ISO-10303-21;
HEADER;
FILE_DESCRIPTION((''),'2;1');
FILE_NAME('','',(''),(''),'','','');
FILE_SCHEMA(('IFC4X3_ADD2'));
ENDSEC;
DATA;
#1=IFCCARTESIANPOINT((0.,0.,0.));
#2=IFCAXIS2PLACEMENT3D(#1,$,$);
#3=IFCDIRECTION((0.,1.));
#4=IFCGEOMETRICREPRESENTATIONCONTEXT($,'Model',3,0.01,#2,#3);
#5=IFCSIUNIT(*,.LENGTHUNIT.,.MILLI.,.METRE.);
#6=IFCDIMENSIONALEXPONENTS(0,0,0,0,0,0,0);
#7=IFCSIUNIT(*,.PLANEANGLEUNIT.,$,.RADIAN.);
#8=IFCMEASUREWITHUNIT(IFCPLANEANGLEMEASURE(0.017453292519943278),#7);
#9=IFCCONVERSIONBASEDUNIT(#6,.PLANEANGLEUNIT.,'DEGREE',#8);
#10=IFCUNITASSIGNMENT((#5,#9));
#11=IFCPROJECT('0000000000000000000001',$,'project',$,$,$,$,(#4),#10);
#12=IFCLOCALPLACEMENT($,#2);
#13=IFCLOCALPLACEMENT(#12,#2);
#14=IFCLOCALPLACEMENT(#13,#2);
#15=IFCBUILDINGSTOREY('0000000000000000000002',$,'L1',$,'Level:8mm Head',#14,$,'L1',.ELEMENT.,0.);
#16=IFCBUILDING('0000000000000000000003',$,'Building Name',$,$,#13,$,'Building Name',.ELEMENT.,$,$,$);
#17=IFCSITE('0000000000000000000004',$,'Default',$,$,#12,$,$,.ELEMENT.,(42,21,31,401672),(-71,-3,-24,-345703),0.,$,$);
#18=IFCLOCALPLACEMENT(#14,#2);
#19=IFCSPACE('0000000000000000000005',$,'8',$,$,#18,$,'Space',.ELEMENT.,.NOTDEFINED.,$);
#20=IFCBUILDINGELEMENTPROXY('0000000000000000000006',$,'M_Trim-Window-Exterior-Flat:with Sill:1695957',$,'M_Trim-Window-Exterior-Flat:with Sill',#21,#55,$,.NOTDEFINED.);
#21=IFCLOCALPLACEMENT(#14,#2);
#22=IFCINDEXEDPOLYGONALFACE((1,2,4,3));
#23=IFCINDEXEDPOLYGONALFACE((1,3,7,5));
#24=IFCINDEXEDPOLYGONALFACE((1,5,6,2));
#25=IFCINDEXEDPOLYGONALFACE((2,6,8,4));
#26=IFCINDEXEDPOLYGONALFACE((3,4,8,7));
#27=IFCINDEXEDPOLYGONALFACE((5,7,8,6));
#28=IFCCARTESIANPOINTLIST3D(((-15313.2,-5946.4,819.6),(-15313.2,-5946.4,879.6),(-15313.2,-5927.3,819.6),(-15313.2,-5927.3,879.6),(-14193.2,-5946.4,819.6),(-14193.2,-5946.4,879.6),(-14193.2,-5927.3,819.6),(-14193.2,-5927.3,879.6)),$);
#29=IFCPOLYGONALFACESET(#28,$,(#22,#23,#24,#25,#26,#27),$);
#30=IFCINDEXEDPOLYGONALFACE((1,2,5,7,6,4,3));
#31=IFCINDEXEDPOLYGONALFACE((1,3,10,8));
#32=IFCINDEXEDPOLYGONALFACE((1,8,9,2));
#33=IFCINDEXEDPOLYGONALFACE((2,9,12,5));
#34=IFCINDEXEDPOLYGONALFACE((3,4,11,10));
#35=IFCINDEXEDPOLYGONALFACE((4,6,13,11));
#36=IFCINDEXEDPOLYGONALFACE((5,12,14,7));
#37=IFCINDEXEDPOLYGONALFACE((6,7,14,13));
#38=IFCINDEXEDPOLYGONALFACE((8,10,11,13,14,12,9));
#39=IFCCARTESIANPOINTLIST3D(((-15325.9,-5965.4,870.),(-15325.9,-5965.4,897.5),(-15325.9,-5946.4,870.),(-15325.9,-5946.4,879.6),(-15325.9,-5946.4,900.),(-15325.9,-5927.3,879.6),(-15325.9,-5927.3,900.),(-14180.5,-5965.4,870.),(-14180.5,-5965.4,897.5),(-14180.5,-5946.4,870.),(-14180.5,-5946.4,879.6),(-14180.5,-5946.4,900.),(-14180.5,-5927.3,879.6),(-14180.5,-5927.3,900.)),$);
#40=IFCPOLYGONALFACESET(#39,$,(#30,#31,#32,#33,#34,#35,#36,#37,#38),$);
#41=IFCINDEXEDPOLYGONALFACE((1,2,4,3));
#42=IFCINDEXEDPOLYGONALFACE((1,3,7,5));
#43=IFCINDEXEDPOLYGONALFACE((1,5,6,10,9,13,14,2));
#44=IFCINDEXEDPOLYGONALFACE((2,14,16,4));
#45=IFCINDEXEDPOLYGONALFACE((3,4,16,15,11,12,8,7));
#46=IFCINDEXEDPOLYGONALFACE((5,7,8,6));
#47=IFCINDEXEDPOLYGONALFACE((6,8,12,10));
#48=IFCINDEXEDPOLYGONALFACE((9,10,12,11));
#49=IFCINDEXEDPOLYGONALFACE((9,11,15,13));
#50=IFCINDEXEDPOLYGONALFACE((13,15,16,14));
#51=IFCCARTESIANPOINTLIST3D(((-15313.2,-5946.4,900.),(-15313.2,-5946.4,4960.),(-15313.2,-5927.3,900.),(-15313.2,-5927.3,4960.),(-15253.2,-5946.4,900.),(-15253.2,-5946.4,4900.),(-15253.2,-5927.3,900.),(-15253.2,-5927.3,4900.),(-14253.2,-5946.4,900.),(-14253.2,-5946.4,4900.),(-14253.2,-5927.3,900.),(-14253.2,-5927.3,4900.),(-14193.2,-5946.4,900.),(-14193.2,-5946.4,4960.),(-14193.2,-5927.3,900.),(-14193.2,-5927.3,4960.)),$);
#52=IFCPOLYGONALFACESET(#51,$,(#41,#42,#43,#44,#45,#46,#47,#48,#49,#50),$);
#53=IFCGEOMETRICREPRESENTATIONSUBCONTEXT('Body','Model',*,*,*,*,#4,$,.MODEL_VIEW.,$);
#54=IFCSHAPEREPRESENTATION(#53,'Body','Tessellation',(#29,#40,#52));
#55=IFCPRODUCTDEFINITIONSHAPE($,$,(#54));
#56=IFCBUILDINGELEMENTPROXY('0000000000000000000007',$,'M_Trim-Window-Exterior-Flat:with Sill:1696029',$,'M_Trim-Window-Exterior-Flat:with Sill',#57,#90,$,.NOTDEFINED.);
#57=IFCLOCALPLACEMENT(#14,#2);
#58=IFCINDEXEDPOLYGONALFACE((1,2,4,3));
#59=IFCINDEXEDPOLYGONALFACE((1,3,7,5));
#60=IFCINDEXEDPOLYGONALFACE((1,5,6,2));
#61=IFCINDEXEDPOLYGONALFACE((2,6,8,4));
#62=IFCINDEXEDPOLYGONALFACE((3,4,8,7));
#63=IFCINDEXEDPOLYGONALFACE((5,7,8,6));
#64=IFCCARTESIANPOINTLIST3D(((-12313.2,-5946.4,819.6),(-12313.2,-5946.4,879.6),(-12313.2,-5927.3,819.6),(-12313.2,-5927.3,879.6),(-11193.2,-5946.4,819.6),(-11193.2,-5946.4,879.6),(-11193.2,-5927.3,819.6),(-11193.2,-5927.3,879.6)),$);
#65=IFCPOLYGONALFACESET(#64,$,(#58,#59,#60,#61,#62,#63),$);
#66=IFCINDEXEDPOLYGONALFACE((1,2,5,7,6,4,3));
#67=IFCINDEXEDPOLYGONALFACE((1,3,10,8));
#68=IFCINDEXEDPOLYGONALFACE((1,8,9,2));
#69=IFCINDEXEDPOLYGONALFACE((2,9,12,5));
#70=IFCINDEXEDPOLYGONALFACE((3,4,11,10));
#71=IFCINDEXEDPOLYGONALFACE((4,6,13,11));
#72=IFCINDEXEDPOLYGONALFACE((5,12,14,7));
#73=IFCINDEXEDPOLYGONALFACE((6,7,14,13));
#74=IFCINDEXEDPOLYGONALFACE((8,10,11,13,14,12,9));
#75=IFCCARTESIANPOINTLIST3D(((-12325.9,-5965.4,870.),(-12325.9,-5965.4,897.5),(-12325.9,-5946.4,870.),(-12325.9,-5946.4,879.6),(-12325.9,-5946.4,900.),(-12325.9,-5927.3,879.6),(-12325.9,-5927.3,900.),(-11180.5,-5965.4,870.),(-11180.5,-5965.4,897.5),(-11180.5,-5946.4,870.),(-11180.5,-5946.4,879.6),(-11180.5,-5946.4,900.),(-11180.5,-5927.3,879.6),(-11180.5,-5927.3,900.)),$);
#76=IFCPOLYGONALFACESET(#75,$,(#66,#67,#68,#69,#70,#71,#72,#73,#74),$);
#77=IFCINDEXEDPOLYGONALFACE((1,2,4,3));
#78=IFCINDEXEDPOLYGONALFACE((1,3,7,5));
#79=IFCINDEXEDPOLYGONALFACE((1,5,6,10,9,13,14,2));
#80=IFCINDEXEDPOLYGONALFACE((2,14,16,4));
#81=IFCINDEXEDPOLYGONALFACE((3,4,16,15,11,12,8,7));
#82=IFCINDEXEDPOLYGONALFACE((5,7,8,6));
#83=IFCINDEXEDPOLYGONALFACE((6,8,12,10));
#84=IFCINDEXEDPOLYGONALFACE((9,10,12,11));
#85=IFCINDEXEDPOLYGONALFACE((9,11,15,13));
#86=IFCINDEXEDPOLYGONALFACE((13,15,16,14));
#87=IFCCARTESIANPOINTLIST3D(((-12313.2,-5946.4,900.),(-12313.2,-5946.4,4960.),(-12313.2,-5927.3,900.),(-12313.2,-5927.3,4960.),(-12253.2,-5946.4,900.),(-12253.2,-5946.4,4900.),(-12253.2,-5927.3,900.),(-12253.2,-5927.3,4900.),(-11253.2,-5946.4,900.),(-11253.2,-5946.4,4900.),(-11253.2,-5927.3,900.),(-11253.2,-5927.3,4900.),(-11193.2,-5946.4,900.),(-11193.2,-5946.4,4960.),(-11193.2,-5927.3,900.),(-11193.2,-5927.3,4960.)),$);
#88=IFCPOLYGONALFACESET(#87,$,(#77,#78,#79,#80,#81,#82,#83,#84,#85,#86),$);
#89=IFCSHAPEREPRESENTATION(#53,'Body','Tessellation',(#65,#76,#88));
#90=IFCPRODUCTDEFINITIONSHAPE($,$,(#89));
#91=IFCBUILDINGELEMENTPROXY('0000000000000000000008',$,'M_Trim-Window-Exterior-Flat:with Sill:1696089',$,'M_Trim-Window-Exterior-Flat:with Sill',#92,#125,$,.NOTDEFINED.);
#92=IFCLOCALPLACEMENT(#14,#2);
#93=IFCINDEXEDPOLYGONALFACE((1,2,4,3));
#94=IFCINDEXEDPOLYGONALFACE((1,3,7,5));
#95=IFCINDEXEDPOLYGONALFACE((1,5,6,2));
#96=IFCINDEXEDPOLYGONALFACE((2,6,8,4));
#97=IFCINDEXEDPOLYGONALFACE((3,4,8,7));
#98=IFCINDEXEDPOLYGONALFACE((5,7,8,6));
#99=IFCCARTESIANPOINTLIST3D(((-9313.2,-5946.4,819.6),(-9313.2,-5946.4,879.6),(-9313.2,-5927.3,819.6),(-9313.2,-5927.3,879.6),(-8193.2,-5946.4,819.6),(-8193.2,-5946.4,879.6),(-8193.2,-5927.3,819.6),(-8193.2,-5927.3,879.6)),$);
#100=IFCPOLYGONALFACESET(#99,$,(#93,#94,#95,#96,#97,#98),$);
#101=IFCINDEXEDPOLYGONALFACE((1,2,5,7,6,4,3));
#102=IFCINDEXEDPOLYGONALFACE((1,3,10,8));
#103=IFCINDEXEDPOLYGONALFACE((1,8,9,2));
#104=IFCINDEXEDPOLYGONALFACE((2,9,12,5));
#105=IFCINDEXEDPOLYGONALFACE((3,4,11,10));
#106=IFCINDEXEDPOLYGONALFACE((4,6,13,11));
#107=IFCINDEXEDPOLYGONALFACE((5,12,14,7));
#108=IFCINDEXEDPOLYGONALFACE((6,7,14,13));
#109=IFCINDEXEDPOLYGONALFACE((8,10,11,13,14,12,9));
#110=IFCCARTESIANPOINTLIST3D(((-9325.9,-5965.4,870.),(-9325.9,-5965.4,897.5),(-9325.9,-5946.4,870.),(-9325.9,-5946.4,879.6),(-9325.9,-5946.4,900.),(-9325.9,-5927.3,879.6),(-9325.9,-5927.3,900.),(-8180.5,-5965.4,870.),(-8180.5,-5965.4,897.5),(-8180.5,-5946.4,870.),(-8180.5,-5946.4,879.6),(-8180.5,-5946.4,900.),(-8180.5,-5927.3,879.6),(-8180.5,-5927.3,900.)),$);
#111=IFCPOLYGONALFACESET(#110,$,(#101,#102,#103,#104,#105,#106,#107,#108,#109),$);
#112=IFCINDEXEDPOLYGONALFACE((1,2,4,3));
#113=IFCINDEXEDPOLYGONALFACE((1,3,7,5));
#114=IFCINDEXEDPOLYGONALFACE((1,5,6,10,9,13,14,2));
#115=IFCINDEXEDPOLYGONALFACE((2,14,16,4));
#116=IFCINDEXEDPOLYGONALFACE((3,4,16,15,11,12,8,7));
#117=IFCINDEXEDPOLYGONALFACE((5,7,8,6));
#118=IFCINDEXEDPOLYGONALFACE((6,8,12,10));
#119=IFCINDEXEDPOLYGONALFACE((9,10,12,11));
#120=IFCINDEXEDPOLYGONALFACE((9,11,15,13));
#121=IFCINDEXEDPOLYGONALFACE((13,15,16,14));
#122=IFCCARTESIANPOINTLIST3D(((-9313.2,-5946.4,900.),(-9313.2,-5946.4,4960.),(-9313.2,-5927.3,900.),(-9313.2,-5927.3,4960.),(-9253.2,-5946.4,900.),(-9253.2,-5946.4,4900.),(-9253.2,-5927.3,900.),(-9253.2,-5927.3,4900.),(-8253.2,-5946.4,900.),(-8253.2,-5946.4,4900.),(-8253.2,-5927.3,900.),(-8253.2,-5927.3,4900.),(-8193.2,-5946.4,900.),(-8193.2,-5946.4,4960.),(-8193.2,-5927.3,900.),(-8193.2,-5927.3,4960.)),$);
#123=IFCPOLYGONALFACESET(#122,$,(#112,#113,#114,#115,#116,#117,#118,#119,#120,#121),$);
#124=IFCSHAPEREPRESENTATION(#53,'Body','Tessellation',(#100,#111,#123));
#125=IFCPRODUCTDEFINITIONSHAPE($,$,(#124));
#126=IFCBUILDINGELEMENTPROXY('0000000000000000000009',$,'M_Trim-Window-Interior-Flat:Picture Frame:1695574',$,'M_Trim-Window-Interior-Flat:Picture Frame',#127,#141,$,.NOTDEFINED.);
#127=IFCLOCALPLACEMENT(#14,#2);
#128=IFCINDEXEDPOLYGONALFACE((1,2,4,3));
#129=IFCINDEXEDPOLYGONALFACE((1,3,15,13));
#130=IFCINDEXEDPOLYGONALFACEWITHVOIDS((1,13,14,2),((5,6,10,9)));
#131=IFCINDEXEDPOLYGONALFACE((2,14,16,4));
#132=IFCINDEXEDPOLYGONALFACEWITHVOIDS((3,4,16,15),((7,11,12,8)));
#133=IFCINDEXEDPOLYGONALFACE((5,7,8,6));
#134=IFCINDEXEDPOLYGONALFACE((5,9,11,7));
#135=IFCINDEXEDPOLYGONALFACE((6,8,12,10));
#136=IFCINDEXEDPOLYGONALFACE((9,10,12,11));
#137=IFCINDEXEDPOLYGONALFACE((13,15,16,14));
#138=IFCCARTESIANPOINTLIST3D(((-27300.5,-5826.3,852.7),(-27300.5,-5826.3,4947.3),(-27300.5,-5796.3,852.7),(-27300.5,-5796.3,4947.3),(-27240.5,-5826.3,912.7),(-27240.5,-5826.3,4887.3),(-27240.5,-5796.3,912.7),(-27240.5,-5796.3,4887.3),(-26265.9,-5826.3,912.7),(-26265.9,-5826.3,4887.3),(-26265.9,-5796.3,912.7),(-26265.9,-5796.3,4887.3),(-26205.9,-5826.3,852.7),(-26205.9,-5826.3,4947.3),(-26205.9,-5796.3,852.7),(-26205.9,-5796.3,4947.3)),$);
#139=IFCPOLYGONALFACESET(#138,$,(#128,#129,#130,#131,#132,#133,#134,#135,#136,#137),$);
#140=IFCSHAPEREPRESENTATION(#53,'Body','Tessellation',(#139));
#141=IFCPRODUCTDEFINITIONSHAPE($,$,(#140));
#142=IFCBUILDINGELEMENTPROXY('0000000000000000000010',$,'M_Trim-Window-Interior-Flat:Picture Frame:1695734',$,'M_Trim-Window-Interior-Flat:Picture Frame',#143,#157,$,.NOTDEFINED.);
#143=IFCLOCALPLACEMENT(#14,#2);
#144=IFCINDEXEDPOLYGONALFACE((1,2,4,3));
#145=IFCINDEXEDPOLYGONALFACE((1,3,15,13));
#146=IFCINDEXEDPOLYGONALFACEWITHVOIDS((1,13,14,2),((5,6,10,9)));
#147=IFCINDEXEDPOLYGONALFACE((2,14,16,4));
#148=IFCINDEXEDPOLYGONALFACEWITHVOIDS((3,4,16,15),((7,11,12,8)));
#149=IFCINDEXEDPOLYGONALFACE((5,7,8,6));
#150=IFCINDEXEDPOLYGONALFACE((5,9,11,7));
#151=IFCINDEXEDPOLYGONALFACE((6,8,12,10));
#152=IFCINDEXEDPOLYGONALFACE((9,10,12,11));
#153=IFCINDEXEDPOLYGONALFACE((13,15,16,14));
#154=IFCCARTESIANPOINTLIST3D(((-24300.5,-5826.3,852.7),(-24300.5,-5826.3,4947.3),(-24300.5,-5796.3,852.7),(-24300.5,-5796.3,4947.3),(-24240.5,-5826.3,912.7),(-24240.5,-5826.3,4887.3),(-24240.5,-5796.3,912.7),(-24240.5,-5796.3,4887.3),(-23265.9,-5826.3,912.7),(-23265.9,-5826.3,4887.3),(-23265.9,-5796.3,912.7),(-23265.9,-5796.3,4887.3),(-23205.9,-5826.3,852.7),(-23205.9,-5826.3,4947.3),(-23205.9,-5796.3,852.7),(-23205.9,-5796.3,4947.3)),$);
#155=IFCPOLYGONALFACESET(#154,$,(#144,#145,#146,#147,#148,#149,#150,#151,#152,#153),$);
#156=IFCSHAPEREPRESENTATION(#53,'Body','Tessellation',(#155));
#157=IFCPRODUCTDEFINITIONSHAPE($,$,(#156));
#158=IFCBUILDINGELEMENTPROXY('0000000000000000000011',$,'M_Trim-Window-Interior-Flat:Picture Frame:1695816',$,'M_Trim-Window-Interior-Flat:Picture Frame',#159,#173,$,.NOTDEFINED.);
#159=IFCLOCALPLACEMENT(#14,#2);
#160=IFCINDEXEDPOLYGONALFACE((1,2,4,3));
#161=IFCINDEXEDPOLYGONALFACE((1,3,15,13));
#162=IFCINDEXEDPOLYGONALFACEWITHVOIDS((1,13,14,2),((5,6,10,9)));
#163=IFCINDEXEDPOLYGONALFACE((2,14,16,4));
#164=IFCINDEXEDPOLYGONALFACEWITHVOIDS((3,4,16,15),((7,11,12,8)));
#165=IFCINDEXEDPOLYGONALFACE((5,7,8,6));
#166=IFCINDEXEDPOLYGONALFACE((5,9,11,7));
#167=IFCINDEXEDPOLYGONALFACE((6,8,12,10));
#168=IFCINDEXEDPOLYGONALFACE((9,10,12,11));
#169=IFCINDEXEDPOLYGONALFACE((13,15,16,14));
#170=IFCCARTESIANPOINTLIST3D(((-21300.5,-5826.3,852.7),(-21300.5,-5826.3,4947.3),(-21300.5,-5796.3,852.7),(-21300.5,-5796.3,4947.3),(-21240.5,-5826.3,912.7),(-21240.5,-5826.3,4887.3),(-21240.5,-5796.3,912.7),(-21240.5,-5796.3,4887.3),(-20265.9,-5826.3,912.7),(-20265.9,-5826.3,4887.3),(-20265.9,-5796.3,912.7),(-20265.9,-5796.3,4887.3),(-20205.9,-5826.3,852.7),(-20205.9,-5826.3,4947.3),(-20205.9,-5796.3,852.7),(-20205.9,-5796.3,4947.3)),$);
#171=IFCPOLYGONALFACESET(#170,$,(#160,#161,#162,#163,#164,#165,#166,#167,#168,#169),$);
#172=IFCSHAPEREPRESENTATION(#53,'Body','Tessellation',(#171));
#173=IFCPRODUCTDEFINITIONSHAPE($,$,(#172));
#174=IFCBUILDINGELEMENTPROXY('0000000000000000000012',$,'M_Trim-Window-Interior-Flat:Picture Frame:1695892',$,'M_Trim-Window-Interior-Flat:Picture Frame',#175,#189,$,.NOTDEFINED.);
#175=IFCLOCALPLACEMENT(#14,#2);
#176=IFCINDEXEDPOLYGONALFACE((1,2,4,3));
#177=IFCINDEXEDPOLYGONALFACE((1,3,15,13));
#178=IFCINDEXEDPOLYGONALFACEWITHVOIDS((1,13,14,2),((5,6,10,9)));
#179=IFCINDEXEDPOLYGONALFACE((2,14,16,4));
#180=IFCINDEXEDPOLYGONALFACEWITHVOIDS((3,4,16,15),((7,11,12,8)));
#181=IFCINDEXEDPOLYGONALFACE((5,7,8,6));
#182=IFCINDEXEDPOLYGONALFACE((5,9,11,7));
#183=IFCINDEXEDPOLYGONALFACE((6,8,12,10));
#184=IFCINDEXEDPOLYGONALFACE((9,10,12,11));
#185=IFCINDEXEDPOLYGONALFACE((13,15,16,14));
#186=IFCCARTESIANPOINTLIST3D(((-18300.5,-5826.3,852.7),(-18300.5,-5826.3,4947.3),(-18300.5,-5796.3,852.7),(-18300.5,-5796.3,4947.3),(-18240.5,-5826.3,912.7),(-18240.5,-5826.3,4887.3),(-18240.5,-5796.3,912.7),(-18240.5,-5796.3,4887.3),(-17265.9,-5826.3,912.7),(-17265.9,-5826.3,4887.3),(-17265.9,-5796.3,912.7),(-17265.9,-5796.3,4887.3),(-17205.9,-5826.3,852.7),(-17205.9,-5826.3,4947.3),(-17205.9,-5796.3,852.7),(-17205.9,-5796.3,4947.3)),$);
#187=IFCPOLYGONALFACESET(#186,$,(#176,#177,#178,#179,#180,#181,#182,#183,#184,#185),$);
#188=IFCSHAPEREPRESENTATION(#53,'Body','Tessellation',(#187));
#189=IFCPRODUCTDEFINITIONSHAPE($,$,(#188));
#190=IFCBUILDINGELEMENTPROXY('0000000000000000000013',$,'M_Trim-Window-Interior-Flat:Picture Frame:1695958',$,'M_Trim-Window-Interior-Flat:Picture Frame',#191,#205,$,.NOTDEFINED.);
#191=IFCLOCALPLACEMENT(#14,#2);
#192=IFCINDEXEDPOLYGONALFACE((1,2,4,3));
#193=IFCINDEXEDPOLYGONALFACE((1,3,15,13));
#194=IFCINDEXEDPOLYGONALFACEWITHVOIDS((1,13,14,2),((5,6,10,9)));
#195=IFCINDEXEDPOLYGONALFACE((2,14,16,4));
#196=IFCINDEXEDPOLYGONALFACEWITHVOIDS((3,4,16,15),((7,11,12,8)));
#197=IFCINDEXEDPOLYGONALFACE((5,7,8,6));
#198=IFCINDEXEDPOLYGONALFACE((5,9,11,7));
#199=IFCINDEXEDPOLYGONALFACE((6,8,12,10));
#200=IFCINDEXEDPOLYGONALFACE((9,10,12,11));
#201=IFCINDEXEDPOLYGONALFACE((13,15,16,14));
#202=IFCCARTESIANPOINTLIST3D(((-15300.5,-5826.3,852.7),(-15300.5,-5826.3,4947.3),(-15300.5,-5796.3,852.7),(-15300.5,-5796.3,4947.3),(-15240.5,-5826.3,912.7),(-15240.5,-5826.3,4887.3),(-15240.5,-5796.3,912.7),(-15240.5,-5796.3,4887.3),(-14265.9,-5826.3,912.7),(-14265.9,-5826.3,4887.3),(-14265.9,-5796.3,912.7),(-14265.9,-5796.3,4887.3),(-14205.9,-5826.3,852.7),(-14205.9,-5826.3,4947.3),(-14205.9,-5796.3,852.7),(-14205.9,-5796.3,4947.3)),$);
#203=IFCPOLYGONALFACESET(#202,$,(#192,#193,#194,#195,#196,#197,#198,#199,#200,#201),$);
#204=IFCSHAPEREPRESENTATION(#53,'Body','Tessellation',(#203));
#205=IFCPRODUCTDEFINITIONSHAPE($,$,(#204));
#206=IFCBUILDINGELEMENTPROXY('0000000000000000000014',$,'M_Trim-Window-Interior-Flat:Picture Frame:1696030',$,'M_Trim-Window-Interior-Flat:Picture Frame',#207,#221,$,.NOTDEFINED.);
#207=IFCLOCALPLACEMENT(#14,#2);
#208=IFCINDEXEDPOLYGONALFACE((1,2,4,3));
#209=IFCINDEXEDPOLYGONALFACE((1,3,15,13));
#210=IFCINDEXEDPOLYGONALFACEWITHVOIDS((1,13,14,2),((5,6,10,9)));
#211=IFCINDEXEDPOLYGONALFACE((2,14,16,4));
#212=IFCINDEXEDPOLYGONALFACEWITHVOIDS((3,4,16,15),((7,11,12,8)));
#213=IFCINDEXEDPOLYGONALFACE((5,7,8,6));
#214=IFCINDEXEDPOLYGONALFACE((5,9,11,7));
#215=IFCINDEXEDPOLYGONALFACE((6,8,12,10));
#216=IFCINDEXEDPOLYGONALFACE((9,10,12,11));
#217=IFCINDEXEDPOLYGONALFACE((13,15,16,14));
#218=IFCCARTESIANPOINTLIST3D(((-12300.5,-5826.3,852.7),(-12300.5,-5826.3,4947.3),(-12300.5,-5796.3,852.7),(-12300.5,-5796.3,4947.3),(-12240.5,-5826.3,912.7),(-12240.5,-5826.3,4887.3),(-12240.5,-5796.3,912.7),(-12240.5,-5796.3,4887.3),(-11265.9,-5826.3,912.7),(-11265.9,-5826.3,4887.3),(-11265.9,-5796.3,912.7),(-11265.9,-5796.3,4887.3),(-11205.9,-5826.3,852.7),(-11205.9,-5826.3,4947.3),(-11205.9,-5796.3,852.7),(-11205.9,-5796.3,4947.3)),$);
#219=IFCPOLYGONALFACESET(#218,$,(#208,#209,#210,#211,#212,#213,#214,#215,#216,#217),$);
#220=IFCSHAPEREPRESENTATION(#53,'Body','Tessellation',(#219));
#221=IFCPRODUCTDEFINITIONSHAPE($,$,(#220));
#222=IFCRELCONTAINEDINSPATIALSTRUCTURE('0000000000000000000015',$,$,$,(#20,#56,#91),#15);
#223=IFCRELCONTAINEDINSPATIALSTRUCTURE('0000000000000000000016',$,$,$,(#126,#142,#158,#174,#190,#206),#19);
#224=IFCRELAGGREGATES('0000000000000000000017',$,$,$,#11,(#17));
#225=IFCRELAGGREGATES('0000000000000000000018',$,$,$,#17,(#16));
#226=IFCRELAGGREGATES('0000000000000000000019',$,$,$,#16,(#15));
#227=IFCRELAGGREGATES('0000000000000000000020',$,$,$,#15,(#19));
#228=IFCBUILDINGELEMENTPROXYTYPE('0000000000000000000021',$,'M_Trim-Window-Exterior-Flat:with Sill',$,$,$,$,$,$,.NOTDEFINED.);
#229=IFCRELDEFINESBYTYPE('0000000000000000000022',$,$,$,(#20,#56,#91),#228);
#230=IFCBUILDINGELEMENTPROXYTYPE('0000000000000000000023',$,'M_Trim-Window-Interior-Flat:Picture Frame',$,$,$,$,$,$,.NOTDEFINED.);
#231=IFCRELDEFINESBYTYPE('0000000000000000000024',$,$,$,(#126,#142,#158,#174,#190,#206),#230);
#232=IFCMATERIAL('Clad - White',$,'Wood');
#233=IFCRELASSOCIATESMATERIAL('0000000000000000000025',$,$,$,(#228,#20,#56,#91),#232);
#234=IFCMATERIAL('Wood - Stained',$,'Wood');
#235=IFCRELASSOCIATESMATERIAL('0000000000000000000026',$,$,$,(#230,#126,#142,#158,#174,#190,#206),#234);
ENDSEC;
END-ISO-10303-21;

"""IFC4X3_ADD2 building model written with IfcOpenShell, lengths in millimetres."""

from ifc_helpers import new_model, entity, si_unit, converted_unit, direction, frame, frame_2d, origin, place, context, subcontext, project, spatial, polyline, rectangle, outline, extrude, source, transform, mapped, material, type_object, type_shapes, element, save


model = new_model("IFC4X3_ADD2")

# Units and contexts
model_context = context("Model", 3, precision=0.01, world=origin(), true_north=direction((0.0, 1.0)))
body_context = subcontext(model_context, "Body", "Model", "MODEL_VIEW")
ifc_project = project(units=[si_unit("LENGTHUNIT", "METRE", prefix="MILLI"), converted_unit("PLANEANGLEUNIT", "DEGREE", entity("IfcPlaneAngleMeasure", 0.017453292519943278), si_unit("PLANEANGLEUNIT", "RADIAN"), dimensions=[0, 0, 0, 0, 0, 0, 0])], contexts=[model_context])

# Site, building, storey
site_placement = place(None, origin())
site = spatial("IfcSite", under=ifc_project, at=site_placement, Name="Default", CompositionType="ELEMENT", RefLatitude=(42, 21, 31, 401672), RefLongitude=(-71, -3, -24, -345703), RefElevation=0.0)
building_placement = place(site_placement, origin())
building = spatial("IfcBuilding", under=site, at=building_placement, Name="Building Name", LongName="Building Name", CompositionType="ELEMENT")
storey_placement = place(building_placement, origin())
storey = spatial("IfcBuildingStorey", under=building, at=storey_placement, Name="L1", ObjectType="Level:8mm Head", LongName="L1", CompositionType="ELEMENT", Elevation=0.0)

# Building element proxies
ifc_material_1 = material(Name="Clad - White", Category="Wood")
ifc_material_2 = material(Name="Wood - Stained", Category="Wood")
building_element_proxy_type_1 = type_object("IfcBuildingElementProxyType", Name="M_Trim-Window-Exterior-Flat:with Sill", PredefinedType="NOTDEFINED", material=ifc_material_1)
shared_shape_1 = source(origin(), body_context, "Body", "SweptSolid", [
    extrude(rectangle(XDim=1120.0, YDim=60.0, at=frame_2d((0.0, 0.0), x_axis=(1.0, 0.0))), frame((0.0, -4050.4, 0.0), z_axis=(0.0, 0.0, 1.0), x_axis=(-1.0, 0.0, 0.0)), (0.0, 0.0, 1.0), 19.0),
    extrude(outline(polyline([(-19.0, -15.2), (0.0, -15.2), (0.0, -5.7), (19.0, -5.7), (19.0, 14.8), (0.0, 14.8), (-19.0, 12.3), (-19.0, -15.2)])), frame((-572.7, -4014.8, 19.0), z_axis=(1.0, 0.0, 0.0), x_axis=(0.0, 0.0, -1.0)), (0.0, 0.0, 1.0), 1145.4),
    extrude(outline(polyline([(-2045.0, -560.0), (2015.0, -560.0), (2015.0, -500.0), (-1985.0, -500.0), (-1985.0, 500.0), (2015.0, 500.0), (2015.0, 560.0), (-2045.0, 560.0), (-2045.0, -560.0)])), frame((0.0, -1985.0, 0.0), z_axis=(0.0, 0.0, 1.0), x_axis=(0.0, -1.0, 0.0)), (0.0, 0.0, 1.0), 19.0),
])
type_shapes(building_element_proxy_type_1, [shared_shape_1])
for number, where, z_axis, x_axis, name in (
    (1, (-14753.2, -5927.3, 4900.0), (0.0, -1.0, 0.0), (1.0, 0.0, 0.0), "M_Trim-Window-Exterior-Flat:with Sill:1695957"),
    (2, (-11753.2, -5927.3, 4900.0), (0.0, -1.0, 0.0), (1.0, 0.0, 0.0), "M_Trim-Window-Exterior-Flat:with Sill:1696029"),
    (3, (-8753.2, -5927.3, 4900.0), (0.0, -1.0, 0.0), (1.0, 0.0, 0.0), "M_Trim-Window-Exterior-Flat:with Sill:1696089"),
):
    element("IfcBuildingElementProxy", number, at=place(storey_placement, frame(where, z_axis=z_axis, x_axis=x_axis)), inside=storey, type_object=building_element_proxy_type_1, material=ifc_material_1, Name=name, ObjectType="M_Trim-Window-Exterior-Flat:with Sill", PredefinedType="NOTDEFINED", context=body_context, shape_type="MappedRepresentation", body=[
        mapped(shared_shape_1, transform((0.0, 0.0, 0.0), scale=1.0)),
    ])

# Shared definitions
space_placement = place(storey_placement, origin())
space = spatial("IfcSpace", under=storey, at=space_placement, Name="8", LongName="Space", CompositionType="ELEMENT", PredefinedType="NOTDEFINED")

# Building element proxies
building_element_proxy_type_2 = type_object("IfcBuildingElementProxyType", Name="M_Trim-Window-Interior-Flat:Picture Frame", PredefinedType="NOTDEFINED", material=ifc_material_2)
shared_shape_2 = source(origin(), body_context, "Body", "SweptSolid", [
    extrude(outline(polyline([(-547.3, -2047.3), (547.3, -2047.3), (547.3, 2047.3), (-547.3, 2047.3), (-547.3, -2047.3)]), holes=[polyline([(-487.3, -1987.3), (-487.3, 1987.3), (487.3, 1987.3), (487.3, -1987.3), (-487.3, -1987.3)])]), frame((0.0, -2000.0, 0.0), z_axis=(0.0, 0.0, 1.0), x_axis=(-1.0, 0.0, 0.0)), (0.0, 0.0, 1.0), 30.0),
])
type_shapes(building_element_proxy_type_2, [shared_shape_2])
for number, where, z_axis, x_axis, name in (
    (4, (-26753.2, -5826.3, 4900.0), (0.0, 1.0, 0.0), (-1.0, 0.0, 0.0), "M_Trim-Window-Interior-Flat:Picture Frame:1695574"),
    (5, (-23753.2, -5826.3, 4900.0), (0.0, 1.0, 0.0), (-1.0, 0.0, 0.0), "M_Trim-Window-Interior-Flat:Picture Frame:1695734"),
    (6, (-20753.2, -5826.3, 4900.0), (0.0, 1.0, 0.0), (-1.0, 0.0, 0.0), "M_Trim-Window-Interior-Flat:Picture Frame:1695816"),
    (7, (-17753.2, -5826.3, 4900.0), (0.0, 1.0, 0.0), (-1.0, 0.0, 0.0), "M_Trim-Window-Interior-Flat:Picture Frame:1695892"),
    (8, (-14753.2, -5826.3, 4900.0), (0.0, 1.0, 0.0), (-1.0, 0.0, 0.0), "M_Trim-Window-Interior-Flat:Picture Frame:1695958"),
    (9, (-11753.2, -5826.3, 4900.0), (0.0, 1.0, 0.0), (-1.0, 0.0, 0.0), "M_Trim-Window-Interior-Flat:Picture Frame:1696030"),
):
    element("IfcBuildingElementProxy", number, at=place(space_placement, frame(where, z_axis=z_axis, x_axis=x_axis)), inside=space, type_object=building_element_proxy_type_2, material=ifc_material_2, Name=name, ObjectType="M_Trim-Window-Interior-Flat:Picture Frame", PredefinedType="NOTDEFINED", context=body_context, shape_type="MappedRepresentation", body=[
        mapped(shared_shape_2, transform((0.0, 0.0, 0.0), scale=1.0)),
    ])

save(model, "model.ifc")
